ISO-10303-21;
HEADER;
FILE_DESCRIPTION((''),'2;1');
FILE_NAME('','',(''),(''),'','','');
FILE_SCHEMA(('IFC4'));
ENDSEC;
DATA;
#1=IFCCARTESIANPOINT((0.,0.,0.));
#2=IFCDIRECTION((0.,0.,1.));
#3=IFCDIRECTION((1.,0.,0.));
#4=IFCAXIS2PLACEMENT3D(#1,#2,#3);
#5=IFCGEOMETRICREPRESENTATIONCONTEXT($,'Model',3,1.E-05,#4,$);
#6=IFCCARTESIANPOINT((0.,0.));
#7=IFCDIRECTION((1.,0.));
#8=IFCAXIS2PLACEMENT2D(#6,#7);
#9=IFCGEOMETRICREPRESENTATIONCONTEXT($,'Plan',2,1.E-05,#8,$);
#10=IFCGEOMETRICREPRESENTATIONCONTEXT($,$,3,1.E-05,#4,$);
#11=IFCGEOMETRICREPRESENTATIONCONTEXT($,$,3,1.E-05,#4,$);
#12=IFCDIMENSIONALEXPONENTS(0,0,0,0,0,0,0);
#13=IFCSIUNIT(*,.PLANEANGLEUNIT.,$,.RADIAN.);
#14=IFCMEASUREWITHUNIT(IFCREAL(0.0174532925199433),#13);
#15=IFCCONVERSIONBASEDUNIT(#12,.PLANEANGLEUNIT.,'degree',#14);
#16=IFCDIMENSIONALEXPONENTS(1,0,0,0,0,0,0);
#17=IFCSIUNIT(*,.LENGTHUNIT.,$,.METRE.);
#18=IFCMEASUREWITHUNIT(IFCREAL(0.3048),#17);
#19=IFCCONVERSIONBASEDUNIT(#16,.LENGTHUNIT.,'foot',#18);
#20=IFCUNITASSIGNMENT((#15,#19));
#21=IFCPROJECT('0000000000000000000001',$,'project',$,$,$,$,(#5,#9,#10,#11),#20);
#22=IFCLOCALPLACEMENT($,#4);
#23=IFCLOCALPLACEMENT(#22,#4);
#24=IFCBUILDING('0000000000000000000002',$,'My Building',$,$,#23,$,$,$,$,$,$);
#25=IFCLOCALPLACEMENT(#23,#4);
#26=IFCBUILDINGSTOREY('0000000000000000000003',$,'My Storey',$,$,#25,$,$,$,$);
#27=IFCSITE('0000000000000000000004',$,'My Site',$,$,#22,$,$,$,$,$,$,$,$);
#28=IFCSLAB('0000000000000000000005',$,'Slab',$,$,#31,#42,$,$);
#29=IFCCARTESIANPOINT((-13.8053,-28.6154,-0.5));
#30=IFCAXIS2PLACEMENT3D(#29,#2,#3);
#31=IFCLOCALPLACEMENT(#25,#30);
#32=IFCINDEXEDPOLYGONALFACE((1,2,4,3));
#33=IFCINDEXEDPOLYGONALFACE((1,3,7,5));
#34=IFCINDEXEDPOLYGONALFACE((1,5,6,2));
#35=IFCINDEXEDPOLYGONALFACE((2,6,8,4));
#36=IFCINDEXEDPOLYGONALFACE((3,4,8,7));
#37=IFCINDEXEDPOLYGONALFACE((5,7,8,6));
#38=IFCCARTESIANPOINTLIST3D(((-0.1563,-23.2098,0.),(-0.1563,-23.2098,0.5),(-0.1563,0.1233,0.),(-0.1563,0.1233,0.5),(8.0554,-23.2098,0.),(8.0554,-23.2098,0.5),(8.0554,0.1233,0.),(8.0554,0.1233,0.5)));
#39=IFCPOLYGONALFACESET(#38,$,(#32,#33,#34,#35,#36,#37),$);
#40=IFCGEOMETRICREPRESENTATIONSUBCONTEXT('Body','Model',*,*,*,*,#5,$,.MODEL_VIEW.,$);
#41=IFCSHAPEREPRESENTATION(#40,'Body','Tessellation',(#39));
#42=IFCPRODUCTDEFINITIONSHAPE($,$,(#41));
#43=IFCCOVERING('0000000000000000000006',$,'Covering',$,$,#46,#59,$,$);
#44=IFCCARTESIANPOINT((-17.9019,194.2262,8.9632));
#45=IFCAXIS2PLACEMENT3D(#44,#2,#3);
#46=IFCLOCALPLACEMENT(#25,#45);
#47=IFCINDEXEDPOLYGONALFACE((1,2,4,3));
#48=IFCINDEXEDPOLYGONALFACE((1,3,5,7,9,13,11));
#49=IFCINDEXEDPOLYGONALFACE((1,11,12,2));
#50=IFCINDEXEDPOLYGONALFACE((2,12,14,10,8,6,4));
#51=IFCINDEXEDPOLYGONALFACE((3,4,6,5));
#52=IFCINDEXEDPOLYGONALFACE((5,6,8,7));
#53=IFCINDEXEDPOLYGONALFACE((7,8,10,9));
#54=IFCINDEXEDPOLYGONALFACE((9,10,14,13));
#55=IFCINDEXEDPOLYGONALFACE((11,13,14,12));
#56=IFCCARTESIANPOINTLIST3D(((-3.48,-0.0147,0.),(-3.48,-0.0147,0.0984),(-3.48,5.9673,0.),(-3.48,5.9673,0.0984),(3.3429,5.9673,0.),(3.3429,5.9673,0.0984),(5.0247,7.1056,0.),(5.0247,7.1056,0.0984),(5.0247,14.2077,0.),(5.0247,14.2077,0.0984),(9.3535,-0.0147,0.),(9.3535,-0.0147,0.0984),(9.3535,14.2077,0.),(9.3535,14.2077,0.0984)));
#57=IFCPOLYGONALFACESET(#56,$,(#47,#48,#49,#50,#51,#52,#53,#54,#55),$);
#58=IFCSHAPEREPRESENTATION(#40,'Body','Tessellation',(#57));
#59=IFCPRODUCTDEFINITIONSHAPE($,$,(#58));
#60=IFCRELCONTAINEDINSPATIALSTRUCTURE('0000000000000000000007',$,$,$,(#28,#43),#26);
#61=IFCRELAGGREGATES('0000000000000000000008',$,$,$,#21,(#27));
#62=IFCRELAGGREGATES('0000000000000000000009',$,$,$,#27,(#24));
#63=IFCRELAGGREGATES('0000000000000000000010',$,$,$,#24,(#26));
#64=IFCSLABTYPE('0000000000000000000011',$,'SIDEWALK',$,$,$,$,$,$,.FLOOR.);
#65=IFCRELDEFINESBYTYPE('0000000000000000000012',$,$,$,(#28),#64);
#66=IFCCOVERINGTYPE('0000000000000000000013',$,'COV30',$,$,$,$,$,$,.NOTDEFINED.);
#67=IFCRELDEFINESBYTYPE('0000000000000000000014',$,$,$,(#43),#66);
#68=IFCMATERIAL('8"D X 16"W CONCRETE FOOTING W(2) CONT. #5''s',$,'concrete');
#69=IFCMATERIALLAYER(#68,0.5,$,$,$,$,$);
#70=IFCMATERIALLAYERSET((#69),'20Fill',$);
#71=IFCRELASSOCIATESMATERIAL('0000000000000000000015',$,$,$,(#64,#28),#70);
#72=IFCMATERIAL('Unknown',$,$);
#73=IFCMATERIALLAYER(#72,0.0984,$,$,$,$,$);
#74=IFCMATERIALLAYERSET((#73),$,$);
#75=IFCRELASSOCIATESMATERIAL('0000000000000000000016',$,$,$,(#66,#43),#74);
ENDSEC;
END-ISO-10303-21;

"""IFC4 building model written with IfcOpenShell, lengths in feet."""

from ifc_helpers import new_model, entity, si_unit, converted_unit, frame, origin_with_axes, origin_2d_with_axis, place, context, subcontext, project, spatial, line, indexed_curve, outline, extrude, material, layer, layer_set, layer_usage, type_object, element, save


model = new_model("IFC4")

# Units and contexts
model_context = context("Model", 3, precision=1e-05, world=origin_with_axes())
plan_context = context("Plan", 2, precision=1e-05, world=origin_2d_with_axis())
context_of_model_1 = context(None, 3, precision=1e-05, world=origin_with_axes())
context_of_model_2 = context(None, 3, precision=1e-05, world=origin_with_axes())
body_context = subcontext(model_context, "Body", "Model", "MODEL_VIEW")
ifc_project = project(units=[converted_unit("PLANEANGLEUNIT", "degree", entity("IfcReal", 0.0174532925199433), si_unit("PLANEANGLEUNIT", "RADIAN"), dimensions=[0, 0, 0, 0, 0, 0, 0]), converted_unit("LENGTHUNIT", "foot", entity("IfcReal", 0.3048), si_unit("LENGTHUNIT", "METRE"), dimensions=[1, 0, 0, 0, 0, 0, 0])], contexts=[model_context, plan_context, context_of_model_1, context_of_model_2])

# Site, building, storey
site_placement = place(None, origin_with_axes())
site = spatial("IfcSite", under=ifc_project, at=site_placement, Name="My Site")
building_placement = place(site_placement, origin_with_axes())
building = spatial("IfcBuilding", under=site, at=building_placement, Name="My Building")
storey_placement = place(building_placement, origin_with_axes())
storey = spatial("IfcBuildingStorey", under=building, at=storey_placement, Name="My Storey")

# Slab
ifc_material_1 = material(Name="8\"D X 16\"W CONCRETE FOOTING W(2) CONT. #5's", Category="concrete")
ifc_layer_1 = layer(ifc_material_1, 0.5)
ifc_layer_set_1 = layer_set([ifc_layer_1], Name="20Fill")
ifc_layer_usage_1 = layer_usage(ifc_layer_set_1, "AXIS3", "POSITIVE", 0.0)
slab_type_1 = type_object("IfcSlabType", Name="SIDEWALK", PredefinedType="FLOOR", material=ifc_layer_set_1)
slab_1_placement = place(storey_placement, frame((-13.8053, -28.6154, -0.5), z_axis=(0.0, 0.0, 1.0), x_axis=(1.0, 0.0, 0.0)))
element("IfcSlab", 1, at=slab_1_placement, inside=storey, type_object=slab_type_1, material=ifc_layer_usage_1, Name="Slab", context=body_context, shape_type="SweptSolid", body=[
    extrude(outline(indexed_curve([(-0.1563, -23.2098), (8.0554, -23.2098), (8.0554, 0.1233), (-0.1563, 0.1233)], segments=[line(3, 2), line(2, 1), line(1, 4), line(4, 3)], self_intersect=False)), None, (0.0, 0.0, 1.0), 0.5),
])

# Covering
ifc_material_2 = material(Name="Unknown")
ifc_layer_2 = layer(ifc_material_2, 0.0984)
ifc_layer_set_2 = layer_set([ifc_layer_2])
ifc_layer_usage_2 = layer_usage(ifc_layer_set_2, "AXIS3", "POSITIVE", 0.0)
covering_type = type_object("IfcCoveringType", Name="COV30", PredefinedType="NOTDEFINED", material=ifc_layer_set_2)
covering_placement = place(storey_placement, frame((-17.9019, 194.2262, 8.9632), z_axis=(0.0, 0.0, 1.0), x_axis=(1.0, 0.0, 0.0)))
element("IfcCovering", 2, at=covering_placement, inside=storey, type_object=covering_type, material=ifc_layer_usage_2, Name="Covering", context=body_context, shape_type="SweptSolid", body=[
    extrude(outline(indexed_curve([(-3.48, 5.9673), (-3.48, -0.0147), (9.3535, -0.0147), (9.3535, 14.2077), (5.0247, 7.1056), (3.3429, 5.9673), (5.0247, 14.2077)], segments=[line(1, 6), line(6, 5), line(5, 7), line(7, 4), line(4, 3), line(3, 2), line(2, 1)], self_intersect=False)), None, (0.0, 0.0, 1.0), 0.0984),
])

save(model, "model.ifc")
